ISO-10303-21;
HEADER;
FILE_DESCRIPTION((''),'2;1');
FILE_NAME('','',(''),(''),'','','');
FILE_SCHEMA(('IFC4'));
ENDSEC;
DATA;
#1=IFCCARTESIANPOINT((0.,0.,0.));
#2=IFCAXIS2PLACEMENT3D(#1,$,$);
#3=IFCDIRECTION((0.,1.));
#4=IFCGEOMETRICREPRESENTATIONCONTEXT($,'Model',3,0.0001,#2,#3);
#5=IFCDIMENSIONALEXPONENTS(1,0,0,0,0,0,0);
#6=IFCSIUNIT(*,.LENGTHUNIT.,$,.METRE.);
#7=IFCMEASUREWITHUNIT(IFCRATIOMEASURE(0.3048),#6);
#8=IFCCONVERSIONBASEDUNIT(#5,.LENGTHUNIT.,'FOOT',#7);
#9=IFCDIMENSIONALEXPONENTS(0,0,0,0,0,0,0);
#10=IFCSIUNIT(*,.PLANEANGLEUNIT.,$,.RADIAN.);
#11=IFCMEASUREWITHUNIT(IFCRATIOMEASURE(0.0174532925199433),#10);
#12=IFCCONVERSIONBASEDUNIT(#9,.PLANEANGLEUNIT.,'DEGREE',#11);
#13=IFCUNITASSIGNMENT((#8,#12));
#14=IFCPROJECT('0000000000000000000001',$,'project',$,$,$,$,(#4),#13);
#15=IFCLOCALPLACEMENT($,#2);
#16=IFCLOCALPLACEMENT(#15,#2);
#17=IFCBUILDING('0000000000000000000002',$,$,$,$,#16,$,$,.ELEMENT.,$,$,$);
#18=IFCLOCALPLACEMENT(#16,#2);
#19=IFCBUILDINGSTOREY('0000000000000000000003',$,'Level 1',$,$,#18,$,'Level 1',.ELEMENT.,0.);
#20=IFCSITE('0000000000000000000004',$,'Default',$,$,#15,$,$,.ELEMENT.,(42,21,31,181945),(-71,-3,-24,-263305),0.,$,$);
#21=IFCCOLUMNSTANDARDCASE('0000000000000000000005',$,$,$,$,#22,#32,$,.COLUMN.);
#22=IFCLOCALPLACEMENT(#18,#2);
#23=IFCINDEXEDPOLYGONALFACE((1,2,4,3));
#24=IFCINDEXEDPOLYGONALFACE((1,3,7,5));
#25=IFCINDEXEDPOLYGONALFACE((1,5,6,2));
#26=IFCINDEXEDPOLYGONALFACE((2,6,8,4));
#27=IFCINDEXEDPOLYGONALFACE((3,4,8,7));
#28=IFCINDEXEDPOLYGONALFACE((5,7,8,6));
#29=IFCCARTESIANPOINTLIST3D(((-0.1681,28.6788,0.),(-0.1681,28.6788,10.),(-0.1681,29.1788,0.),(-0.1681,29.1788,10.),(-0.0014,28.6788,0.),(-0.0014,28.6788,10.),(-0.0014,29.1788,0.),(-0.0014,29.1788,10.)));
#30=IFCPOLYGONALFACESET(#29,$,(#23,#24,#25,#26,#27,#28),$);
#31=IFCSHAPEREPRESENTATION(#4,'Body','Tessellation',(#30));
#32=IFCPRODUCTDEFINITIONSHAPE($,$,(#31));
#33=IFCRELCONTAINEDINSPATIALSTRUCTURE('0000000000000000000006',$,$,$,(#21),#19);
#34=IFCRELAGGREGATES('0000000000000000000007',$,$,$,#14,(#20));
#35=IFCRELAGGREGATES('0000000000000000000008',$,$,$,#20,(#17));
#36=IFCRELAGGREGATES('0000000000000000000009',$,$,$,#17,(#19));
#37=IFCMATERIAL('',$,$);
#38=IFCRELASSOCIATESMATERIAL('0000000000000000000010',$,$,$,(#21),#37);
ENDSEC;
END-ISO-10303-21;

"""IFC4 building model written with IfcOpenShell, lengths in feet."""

from ifc_helpers import new_model, entity, si_unit, converted_unit, direction, frame, origin, place, context, project, spatial, rectangle, extrude, material, element, save


model = new_model("IFC4")

# Units and contexts
model_context = context("Model", 3, precision=0.0001, world=origin(), true_north=direction((0.0, 1.0)))
ifc_project = project(units=[converted_unit("LENGTHUNIT", "FOOT", entity("IfcRatioMeasure", 0.3048), si_unit("LENGTHUNIT", "METRE"), dimensions=[1, 0, 0, 0, 0, 0, 0]), converted_unit("PLANEANGLEUNIT", "DEGREE", entity("IfcRatioMeasure", 0.0174532925199433), si_unit("PLANEANGLEUNIT", "RADIAN"), dimensions=[0, 0, 0, 0, 0, 0, 0])], contexts=[model_context])

# Site, building, storey
site_placement = place(None, origin())
site = spatial("IfcSite", under=ifc_project, at=site_placement, Name="Default", CompositionType="ELEMENT", RefLatitude=(42, 21, 31, 181945), RefLongitude=(-71, -3, -24, -263305), RefElevation=0.0)
building_placement = place(site_placement, origin())
building = spatial("IfcBuilding", under=site, at=building_placement, CompositionType="ELEMENT")
storey_placement = place(building_placement, origin())
storey = spatial("IfcBuildingStorey", under=building, at=storey_placement, Name="Level 1", LongName="Level 1", CompositionType="ELEMENT", Elevation=0.0)

# Column
ifc_material_1 = material(Name="")
placement_1 = place(storey_placement, frame((-0.1681, 28.9288, 0.0)))
column_placement = place(placement_1, frame((0.0833, 0.0, 0.0), z_axis=(0.0, 0.0, 1.0), x_axis=(1.0, 0.0, 0.0)))
element("IfcColumnStandardCase", 1, at=column_placement, inside=storey, material=ifc_material_1, PredefinedType="COLUMN", context=model_context, shape_type="SweptSolid", body=[
    extrude(rectangle(XDim=0.1667, YDim=0.5), origin(), (0.0, 0.0, 1.0), 10.0),
])

save(model, "model.ifc")
